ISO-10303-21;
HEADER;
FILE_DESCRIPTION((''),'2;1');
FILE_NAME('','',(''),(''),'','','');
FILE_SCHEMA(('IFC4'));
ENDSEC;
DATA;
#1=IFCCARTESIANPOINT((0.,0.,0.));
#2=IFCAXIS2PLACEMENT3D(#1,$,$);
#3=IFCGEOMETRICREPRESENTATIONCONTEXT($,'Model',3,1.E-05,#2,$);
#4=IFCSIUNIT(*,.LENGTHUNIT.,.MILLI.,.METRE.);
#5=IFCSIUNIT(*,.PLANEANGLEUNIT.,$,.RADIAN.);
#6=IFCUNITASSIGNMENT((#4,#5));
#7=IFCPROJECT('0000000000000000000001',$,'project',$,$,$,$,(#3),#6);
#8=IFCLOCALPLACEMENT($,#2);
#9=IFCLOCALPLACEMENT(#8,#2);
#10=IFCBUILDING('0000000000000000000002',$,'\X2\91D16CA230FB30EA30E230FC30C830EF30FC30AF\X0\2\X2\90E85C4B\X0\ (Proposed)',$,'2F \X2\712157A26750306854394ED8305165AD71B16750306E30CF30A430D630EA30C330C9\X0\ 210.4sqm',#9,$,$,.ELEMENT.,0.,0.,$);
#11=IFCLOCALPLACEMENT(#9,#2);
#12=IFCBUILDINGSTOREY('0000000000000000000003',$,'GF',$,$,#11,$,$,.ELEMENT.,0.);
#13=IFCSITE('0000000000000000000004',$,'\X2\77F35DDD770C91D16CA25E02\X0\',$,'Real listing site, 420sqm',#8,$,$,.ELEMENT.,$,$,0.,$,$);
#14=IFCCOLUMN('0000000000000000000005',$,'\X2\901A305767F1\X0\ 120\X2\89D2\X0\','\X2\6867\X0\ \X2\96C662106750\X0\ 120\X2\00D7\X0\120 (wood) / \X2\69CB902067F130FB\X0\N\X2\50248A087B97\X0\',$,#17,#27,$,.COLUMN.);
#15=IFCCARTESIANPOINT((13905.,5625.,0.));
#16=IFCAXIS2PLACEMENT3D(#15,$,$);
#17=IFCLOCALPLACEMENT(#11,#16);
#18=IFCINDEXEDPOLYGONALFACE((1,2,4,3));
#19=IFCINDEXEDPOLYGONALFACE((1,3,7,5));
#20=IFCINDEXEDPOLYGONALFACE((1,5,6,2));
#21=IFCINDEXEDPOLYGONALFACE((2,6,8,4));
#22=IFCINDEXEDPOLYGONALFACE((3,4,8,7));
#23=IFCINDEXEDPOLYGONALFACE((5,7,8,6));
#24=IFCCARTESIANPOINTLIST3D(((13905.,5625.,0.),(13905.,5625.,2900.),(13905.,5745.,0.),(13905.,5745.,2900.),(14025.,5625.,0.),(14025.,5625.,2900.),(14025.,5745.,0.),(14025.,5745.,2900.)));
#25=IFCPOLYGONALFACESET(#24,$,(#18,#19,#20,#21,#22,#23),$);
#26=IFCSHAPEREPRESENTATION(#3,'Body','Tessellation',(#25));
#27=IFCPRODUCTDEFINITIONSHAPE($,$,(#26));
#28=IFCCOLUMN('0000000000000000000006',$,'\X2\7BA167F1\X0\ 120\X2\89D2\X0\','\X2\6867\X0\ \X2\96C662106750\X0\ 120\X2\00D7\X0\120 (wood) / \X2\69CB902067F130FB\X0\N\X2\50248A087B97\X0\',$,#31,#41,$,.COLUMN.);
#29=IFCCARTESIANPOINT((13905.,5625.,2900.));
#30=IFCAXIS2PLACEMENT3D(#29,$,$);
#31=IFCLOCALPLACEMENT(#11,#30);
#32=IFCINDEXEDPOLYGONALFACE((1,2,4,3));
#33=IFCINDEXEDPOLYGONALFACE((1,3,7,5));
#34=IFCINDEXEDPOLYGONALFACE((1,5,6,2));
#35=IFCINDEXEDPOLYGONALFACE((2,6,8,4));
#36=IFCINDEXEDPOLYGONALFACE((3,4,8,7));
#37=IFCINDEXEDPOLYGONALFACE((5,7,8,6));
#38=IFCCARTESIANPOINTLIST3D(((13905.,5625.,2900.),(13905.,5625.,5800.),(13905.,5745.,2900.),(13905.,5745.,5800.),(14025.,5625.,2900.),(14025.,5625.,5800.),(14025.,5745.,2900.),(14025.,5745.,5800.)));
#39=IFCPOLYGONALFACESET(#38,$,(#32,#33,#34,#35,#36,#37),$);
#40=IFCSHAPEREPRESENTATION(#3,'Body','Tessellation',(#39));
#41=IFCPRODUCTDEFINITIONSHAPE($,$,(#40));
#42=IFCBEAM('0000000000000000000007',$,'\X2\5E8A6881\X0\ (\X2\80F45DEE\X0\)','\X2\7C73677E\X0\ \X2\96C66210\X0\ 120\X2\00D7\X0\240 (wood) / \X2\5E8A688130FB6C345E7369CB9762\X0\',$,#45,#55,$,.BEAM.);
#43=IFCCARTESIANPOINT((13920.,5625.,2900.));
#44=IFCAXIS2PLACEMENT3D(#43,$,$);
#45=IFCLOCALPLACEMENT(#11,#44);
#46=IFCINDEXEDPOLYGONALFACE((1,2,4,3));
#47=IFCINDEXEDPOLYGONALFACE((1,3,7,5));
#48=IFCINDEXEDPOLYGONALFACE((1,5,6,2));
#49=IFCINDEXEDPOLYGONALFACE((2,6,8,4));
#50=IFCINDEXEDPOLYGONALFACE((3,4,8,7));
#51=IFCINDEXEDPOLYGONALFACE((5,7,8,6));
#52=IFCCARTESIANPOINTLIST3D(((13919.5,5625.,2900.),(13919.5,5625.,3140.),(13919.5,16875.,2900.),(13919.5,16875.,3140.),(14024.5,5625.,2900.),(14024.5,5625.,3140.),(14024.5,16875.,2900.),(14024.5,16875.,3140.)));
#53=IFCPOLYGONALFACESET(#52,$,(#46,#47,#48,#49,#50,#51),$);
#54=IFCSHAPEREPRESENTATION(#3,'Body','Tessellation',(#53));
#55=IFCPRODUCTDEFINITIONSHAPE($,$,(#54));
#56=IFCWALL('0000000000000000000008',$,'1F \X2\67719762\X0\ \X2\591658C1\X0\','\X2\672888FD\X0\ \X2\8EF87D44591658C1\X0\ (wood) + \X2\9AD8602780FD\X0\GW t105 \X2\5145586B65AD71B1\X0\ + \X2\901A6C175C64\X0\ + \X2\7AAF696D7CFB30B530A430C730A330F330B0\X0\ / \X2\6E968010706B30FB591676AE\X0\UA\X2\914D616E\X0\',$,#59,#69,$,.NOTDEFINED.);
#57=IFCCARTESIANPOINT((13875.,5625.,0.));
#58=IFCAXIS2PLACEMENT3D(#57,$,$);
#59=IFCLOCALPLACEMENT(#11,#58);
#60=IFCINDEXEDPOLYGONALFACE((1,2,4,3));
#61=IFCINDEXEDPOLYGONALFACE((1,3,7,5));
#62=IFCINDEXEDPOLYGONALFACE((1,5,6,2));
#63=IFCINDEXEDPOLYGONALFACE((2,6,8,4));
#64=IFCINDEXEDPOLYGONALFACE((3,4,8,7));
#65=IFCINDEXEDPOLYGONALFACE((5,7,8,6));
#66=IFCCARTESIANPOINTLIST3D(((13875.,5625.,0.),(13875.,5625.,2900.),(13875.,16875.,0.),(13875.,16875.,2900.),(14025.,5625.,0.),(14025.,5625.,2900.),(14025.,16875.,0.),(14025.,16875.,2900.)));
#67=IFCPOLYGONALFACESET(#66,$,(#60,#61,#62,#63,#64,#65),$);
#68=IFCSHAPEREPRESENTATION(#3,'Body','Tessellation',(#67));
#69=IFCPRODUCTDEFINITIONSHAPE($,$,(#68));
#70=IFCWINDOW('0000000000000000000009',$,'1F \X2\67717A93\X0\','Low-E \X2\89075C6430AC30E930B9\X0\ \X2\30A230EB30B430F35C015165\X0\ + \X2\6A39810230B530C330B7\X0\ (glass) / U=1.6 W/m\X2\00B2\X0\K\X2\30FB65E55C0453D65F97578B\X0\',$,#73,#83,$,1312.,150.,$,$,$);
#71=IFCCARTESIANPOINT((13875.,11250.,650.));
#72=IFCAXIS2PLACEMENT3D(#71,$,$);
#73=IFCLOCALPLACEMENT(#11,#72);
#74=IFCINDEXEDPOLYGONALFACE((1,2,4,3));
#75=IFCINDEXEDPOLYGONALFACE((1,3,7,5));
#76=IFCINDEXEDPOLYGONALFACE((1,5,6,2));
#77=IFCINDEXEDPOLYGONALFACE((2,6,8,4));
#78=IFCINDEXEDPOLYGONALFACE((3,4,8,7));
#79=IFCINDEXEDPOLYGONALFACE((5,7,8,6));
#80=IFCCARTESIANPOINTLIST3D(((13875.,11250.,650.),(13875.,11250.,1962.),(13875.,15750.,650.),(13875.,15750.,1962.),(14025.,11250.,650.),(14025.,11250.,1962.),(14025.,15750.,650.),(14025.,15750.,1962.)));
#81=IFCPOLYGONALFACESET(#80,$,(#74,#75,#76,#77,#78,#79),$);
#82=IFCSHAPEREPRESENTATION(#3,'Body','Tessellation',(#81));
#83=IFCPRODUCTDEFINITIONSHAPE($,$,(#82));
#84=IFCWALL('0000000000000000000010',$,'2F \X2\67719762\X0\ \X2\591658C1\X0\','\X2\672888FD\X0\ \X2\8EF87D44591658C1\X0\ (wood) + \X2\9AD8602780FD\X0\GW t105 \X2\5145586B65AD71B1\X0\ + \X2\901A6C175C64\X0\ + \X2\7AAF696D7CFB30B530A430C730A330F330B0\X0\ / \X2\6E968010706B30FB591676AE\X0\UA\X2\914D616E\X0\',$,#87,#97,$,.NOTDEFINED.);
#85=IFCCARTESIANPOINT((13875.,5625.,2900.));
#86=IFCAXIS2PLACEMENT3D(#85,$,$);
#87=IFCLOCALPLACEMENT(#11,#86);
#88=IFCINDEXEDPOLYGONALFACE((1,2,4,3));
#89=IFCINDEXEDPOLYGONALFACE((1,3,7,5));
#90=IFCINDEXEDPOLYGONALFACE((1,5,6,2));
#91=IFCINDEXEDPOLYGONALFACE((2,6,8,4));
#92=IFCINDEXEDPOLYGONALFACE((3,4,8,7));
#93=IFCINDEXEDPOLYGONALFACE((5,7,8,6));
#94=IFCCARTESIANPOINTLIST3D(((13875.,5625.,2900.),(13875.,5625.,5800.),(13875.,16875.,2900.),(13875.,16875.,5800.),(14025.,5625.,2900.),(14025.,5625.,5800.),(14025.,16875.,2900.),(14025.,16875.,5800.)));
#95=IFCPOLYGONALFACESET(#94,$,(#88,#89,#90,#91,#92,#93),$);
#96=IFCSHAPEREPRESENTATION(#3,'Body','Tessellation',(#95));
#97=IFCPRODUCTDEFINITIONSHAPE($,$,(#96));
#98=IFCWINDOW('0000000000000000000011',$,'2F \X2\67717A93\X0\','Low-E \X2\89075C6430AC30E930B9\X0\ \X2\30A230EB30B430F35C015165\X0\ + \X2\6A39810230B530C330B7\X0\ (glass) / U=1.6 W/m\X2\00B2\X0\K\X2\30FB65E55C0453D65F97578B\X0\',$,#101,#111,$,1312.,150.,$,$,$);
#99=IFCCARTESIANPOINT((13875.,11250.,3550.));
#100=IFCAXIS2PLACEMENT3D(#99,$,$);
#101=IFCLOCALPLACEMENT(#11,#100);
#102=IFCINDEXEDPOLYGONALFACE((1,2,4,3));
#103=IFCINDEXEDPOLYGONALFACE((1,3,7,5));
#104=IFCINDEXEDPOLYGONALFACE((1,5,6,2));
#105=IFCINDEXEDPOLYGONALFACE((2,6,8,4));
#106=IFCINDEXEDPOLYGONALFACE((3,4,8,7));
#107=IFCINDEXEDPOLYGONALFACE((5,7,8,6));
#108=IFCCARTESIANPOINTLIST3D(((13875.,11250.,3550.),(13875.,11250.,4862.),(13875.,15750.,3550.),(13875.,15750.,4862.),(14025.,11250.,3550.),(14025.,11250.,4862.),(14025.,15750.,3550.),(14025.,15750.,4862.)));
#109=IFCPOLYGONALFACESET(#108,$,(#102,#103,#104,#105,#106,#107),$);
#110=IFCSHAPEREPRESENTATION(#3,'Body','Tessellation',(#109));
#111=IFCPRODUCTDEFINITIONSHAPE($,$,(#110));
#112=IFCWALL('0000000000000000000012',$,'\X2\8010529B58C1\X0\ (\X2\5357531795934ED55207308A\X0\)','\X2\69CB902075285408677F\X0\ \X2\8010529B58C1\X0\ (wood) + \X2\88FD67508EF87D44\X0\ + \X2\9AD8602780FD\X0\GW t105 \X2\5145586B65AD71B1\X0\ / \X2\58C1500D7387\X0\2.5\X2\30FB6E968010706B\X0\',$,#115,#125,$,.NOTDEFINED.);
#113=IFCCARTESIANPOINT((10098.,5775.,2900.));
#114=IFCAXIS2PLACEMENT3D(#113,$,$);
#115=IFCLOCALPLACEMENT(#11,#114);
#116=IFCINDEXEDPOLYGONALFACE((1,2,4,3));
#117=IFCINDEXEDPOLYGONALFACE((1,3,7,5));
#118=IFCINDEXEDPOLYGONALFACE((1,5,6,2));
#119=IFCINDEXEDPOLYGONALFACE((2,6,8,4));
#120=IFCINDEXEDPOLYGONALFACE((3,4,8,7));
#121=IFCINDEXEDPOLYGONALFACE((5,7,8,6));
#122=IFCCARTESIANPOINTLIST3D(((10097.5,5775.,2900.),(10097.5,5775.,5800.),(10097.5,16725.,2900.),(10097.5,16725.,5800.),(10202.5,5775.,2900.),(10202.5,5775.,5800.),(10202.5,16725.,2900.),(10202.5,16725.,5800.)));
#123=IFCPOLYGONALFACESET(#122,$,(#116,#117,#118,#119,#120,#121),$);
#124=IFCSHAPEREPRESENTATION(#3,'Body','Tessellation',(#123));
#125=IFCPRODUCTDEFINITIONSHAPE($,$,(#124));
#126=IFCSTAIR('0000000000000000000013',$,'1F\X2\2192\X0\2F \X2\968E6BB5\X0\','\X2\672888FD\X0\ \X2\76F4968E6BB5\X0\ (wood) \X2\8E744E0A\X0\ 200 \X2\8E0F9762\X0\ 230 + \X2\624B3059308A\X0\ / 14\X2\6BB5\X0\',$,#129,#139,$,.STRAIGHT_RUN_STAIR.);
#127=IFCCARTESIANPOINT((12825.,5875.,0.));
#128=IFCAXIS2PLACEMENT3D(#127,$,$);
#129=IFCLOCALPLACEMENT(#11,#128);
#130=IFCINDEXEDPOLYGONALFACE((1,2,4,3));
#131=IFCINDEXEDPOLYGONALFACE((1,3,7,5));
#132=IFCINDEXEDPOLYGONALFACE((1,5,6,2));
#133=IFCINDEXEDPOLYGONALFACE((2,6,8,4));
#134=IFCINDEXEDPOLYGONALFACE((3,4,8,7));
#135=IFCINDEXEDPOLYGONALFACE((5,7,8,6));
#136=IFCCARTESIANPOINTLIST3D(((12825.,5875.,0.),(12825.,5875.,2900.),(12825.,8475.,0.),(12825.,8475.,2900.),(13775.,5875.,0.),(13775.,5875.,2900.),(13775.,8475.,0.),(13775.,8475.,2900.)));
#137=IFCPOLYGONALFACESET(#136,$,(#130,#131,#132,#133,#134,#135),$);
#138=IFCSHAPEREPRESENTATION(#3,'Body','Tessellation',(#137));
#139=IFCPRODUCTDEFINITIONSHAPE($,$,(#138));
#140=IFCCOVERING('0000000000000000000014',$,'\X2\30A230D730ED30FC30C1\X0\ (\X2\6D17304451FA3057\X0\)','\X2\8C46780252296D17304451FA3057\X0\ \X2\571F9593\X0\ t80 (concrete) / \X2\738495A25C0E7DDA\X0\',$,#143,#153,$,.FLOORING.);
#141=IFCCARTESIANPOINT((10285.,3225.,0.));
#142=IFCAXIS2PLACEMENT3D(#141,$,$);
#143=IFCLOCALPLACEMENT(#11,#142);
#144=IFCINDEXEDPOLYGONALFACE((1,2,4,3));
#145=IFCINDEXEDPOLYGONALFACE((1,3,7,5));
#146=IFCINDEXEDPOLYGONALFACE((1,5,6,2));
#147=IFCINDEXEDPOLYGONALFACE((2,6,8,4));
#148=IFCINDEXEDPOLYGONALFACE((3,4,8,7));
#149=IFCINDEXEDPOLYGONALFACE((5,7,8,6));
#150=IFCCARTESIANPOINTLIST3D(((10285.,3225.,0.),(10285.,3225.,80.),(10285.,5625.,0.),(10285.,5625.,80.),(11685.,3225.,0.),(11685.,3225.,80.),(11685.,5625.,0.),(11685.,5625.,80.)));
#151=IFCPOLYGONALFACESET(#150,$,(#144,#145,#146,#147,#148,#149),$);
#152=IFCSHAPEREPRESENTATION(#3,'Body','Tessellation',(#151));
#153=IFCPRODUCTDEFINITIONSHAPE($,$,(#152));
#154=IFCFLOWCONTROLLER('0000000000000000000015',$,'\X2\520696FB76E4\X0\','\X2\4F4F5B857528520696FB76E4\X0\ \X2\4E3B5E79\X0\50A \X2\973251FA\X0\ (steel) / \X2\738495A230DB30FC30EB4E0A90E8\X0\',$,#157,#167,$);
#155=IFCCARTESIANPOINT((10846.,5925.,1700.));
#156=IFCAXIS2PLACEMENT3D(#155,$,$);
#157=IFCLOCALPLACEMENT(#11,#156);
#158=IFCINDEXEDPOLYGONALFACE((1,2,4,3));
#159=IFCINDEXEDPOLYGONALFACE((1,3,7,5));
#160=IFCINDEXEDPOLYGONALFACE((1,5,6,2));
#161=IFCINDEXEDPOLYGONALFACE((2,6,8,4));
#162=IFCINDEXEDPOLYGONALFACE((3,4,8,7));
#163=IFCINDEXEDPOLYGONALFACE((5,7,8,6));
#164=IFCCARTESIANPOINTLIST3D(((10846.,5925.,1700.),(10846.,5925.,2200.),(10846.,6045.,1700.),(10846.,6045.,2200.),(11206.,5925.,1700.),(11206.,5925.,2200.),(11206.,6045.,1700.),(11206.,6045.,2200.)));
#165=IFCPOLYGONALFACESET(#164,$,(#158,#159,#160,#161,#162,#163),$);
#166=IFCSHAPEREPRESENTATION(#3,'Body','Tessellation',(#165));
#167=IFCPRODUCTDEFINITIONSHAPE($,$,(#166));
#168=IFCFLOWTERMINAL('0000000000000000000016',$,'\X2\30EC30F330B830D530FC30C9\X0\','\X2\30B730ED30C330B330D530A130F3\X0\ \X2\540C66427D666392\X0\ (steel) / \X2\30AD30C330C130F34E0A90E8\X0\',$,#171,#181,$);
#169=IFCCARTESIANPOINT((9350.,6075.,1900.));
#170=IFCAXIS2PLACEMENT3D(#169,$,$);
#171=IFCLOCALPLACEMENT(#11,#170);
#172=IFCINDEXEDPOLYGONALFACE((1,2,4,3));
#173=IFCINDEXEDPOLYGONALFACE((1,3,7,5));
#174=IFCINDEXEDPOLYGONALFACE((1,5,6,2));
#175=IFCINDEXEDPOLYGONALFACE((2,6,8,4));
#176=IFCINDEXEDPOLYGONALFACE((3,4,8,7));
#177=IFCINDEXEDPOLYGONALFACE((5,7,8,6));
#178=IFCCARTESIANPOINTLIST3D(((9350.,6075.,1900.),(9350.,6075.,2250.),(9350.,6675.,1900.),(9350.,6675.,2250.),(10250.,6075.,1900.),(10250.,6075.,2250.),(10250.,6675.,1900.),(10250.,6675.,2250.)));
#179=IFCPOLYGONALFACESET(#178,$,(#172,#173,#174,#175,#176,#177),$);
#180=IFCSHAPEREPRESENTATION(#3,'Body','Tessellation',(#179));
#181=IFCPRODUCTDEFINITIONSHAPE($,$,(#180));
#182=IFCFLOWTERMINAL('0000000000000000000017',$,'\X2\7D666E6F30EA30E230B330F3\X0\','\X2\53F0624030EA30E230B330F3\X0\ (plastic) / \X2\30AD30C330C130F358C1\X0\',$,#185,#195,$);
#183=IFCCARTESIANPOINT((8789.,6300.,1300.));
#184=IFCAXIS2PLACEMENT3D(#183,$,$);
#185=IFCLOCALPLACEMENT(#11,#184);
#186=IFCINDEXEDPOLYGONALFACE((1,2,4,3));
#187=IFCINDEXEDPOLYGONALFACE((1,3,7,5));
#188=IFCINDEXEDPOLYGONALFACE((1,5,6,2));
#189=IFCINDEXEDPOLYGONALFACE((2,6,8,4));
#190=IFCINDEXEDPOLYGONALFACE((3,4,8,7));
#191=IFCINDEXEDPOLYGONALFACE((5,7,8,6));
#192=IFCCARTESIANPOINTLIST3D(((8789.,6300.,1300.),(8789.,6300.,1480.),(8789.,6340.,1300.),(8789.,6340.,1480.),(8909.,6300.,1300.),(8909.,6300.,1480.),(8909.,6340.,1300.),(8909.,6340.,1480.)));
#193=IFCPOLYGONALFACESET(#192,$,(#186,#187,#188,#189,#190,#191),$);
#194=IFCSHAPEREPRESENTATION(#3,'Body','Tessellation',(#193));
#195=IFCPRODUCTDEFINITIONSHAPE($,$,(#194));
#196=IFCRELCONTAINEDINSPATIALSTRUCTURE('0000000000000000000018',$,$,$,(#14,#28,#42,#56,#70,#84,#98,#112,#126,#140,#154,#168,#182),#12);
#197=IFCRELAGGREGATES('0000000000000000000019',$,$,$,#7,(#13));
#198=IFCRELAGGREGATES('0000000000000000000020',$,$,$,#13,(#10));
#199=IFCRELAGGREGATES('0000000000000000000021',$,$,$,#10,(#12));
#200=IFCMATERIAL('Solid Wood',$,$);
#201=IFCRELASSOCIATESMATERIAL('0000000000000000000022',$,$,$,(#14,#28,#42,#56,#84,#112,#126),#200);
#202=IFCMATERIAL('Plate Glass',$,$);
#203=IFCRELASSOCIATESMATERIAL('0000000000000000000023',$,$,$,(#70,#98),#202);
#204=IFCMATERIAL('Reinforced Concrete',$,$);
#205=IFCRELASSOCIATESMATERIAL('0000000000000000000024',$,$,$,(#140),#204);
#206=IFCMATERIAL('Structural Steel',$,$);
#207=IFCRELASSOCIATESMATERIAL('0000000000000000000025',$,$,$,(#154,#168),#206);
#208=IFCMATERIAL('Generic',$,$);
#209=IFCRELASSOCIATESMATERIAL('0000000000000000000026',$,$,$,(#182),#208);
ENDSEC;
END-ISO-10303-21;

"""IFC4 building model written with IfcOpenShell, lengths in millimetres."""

from ifc_helpers import new_model, si_unit, frame, frame_2d, origin, place, context, project, spatial, rectangle, extrude, material, element, fill, save


model = new_model("IFC4")

# Units and contexts
model_context = context("Model", 3, precision=1e-05, world=origin())
ifc_project = project(units=[si_unit("LENGTHUNIT", "METRE", prefix="MILLI"), si_unit("PLANEANGLEUNIT", "RADIAN")], contexts=[model_context])

# Site, building, storey
site_placement = place(None, origin())
site = spatial("IfcSite", under=ifc_project, at=site_placement, Name="石川県金沢市", ObjectType="Real listing site, 420sqm", CompositionType="ELEMENT", RefElevation=0.0)
building_placement = place(site_placement, origin())
building = spatial("IfcBuilding", under=site, at=building_placement, Name="金沢・リモートワーク2部屋 (Proposed)", ObjectType="2F 無垢材と吹付け断熱材のハイブリッド 210.4sqm", CompositionType="ELEMENT", ElevationOfRefHeight=0.0, ElevationOfTerrain=0.0)
storey_placement = place(building_placement, origin())
storey = spatial("IfcBuildingStorey", under=building, at=storey_placement, Name="GF", CompositionType="ELEMENT", Elevation=0.0)

# Columns
ifc_material_1 = material(Name="Solid Wood")
column_1_placement = place(storey_placement, frame((13905.0, 5625.0, 0.0)))
element("IfcColumn", 1, at=column_1_placement, inside=storey, material=ifc_material_1, Name="通し柱 120角", Description="桧 集成材 120×120 (wood) / 構造柱・N値計算", PredefinedType="COLUMN", context=model_context, shape_type="SweptSolid", body=[
    extrude(rectangle(XDim=120.0, YDim=120.0, at=frame_2d((60.0, 60.0))), frame((13905.0, 5625.0, 0.0)), (0.0, 0.0, 1.0), 2900.0),
])
column_2_placement = place(storey_placement, frame((13905.0, 5625.0, 2900.0)))
element("IfcColumn", 2, at=column_2_placement, inside=storey, material=ifc_material_1, Name="管柱 120角", Description="桧 集成材 120×120 (wood) / 構造柱・N値計算", PredefinedType="COLUMN", context=model_context, shape_type="SweptSolid", body=[
    extrude(rectangle(XDim=120.0, YDim=120.0, at=frame_2d((60.0, 60.0))), frame((13905.0, 5625.0, 2900.0)), (0.0, 0.0, 1.0), 2900.0),
])

# Beam
beam_1_placement = place(storey_placement, frame((13920.0, 5625.0, 2900.0)))
element("IfcBeam", 3, at=beam_1_placement, inside=storey, material=ifc_material_1, Name="床梁 (胴差)", Description="米松 集成 120×240 (wood) / 床梁・水平構面", PredefinedType="BEAM", context=model_context, shape_type="SweptSolid", body=[
    extrude(rectangle(XDim=105.0, YDim=11250.0, at=frame_2d((52.0, 5625.0))), frame((13920.0, 5625.0, 2900.0)), (0.0, 0.0, 1.0), 240.0),
])

# Wall, opening, window
wall_1_placement = place(storey_placement, frame((13875.0, 5625.0, 0.0)))
wall_1 = element("IfcWall", 4, at=wall_1_placement, inside=storey, material=ifc_material_1, Name="1F 東面 外壁", Description="木製 軸組外壁 (wood) + 高性能GW t105 充填断熱 + 通気層 + 窯業系サイディング / 準耐火・外皮UA配慮", PredefinedType="NOTDEFINED", context=model_context, shape_type="SweptSolid", body=[
    extrude(rectangle(XDim=150.0, YDim=11250.0, at=frame_2d((75.0, 5625.0))), frame((13875.0, 5625.0, 0.0)), (0.0, 0.0, 1.0), 2900.0),
])
opening_1_placement = place(storey_placement, frame((13875.0, 11250.0, 650.0)))
opening_1 = element("IfcOpeningElement", 5, at=opening_1_placement, cuts=wall_1, PredefinedType="NOTDEFINED", context=model_context, shape_type="SweptSolid", body=[
    extrude(rectangle(XDim=150.0, YDim=4500.0, at=frame_2d((75.0, 2250.0))), frame((13875.0, 11250.0, 650.0)), (0.0, 0.0, 1.0), 1312.0),
])
ifc_material_2 = material(Name="Plate Glass")
window_1_placement = place(storey_placement, frame((13875.0, 11250.0, 650.0)))
window_1 = element("IfcWindow", 6, at=window_1_placement, inside=storey, material=ifc_material_2, Name="1F 東窓", Description="Low-E 複層ガラス アルゴン封入 + 樹脂サッシ (glass) / U=1.6 W/m²K・日射取得型", OverallHeight=1312.0, OverallWidth=150.0, context=model_context, shape_type="SweptSolid", body=[
    extrude(rectangle(XDim=150.0, YDim=4500.0, at=frame_2d((75.0, 2250.0))), frame((13875.0, 11250.0, 650.0)), (0.0, 0.0, 1.0), 1312.0),
])
fill(opening_1, window_1)

# Wall, opening, window
wall_2_placement = place(storey_placement, frame((13875.0, 5625.0, 2900.0)))
wall_2 = element("IfcWall", 7, at=wall_2_placement, inside=storey, material=ifc_material_1, Name="2F 東面 外壁", Description="木製 軸組外壁 (wood) + 高性能GW t105 充填断熱 + 通気層 + 窯業系サイディング / 準耐火・外皮UA配慮", PredefinedType="NOTDEFINED", context=model_context, shape_type="SweptSolid", body=[
    extrude(rectangle(XDim=150.0, YDim=11250.0, at=frame_2d((75.0, 5625.0))), frame((13875.0, 5625.0, 2900.0)), (0.0, 0.0, 1.0), 2900.0),
])
opening_2_placement = place(storey_placement, frame((13875.0, 11250.0, 3550.0)))
opening_2 = element("IfcOpeningElement", 8, at=opening_2_placement, cuts=wall_2, PredefinedType="NOTDEFINED", context=model_context, shape_type="SweptSolid", body=[
    extrude(rectangle(XDim=150.0, YDim=4500.0, at=frame_2d((75.0, 2250.0))), frame((13875.0, 11250.0, 3550.0)), (0.0, 0.0, 1.0), 1312.0),
])
window_2_placement = place(storey_placement, frame((13875.0, 11250.0, 3550.0)))
window_2 = element("IfcWindow", 9, at=window_2_placement, inside=storey, material=ifc_material_2, Name="2F 東窓", Description="Low-E 複層ガラス アルゴン封入 + 樹脂サッシ (glass) / U=1.6 W/m²K・日射取得型", OverallHeight=1312.0, OverallWidth=150.0, context=model_context, shape_type="SweptSolid", body=[
    extrude(rectangle(XDim=150.0, YDim=4500.0, at=frame_2d((75.0, 2250.0))), frame((13875.0, 11250.0, 3550.0)), (0.0, 0.0, 1.0), 1312.0),
])
fill(opening_2, window_2)

# Wall
wall_3_placement = place(storey_placement, frame((10098.0, 5775.0, 2900.0)))
element("IfcWall", 10, at=wall_3_placement, inside=storey, material=ifc_material_1, Name="耐力壁 (南北間仕切り)", Description="構造用合板 耐力壁 (wood) + 製材軸組 + 高性能GW t105 充填断熱 / 壁倍率2.5・準耐火", PredefinedType="NOTDEFINED", context=model_context, shape_type="SweptSolid", body=[
    extrude(rectangle(XDim=105.0, YDim=10950.0, at=frame_2d((52.0, 5475.0))), frame((10098.0, 5775.0, 2900.0)), (0.0, 0.0, 1.0), 2900.0),
])

# Stair
stair_placement = place(storey_placement, frame((12825.0, 5875.0, 0.0)))
element("IfcStair", 11, at=stair_placement, inside=storey, material=ifc_material_1, Name="1F→2F 階段", Description="木製 直階段 (wood) 蹴上 200 踏面 230 + 手すり / 14段", PredefinedType="STRAIGHT_RUN_STAIR", context=model_context, shape_type="SweptSolid", body=[
    extrude(rectangle(XDim=950.0, YDim=2600.0, at=frame_2d((475.0, 1300.0))), frame((12825.0, 5875.0, 0.0)), (0.0, 0.0, 1.0), 2900.0),
])

# Covering
ifc_material_3 = material(Name="Reinforced Concrete")
covering_placement = place(storey_placement, frame((10285.0, 3225.0, 0.0)))
element("IfcCovering", 12, at=covering_placement, inside=storey, material=ifc_material_3, Name="アプローチ (洗い出し)", Description="豆砂利洗い出し 土間 t80 (concrete) / 玄関導線", PredefinedType="FLOORING", context=model_context, shape_type="SweptSolid", body=[
    extrude(rectangle(XDim=1400.0, YDim=2400.0, at=frame_2d((700.0, 1200.0))), frame((10285.0, 3225.0, 0.0)), (0.0, 0.0, 1.0), 80.0),
])

# Flow controller
ifc_material_4 = material(Name="Structural Steel")
flow_controller_placement = place(storey_placement, frame((10846.0, 5925.0, 1700.0)))
element("IfcFlowController", 13, at=flow_controller_placement, inside=storey, material=ifc_material_4, Name="分電盤", Description="住宅用分電盤 主幹50A 露出 (steel) / 玄関ホール上部", context=model_context, shape_type="SweptSolid", body=[
    extrude(rectangle(XDim=360.0, YDim=120.0, at=frame_2d((180.0, 60.0))), frame((10846.0, 5925.0, 1700.0)), (0.0, 0.0, 1.0), 500.0),
])

# Flow terminals
flow_terminal_1_placement = place(storey_placement, frame((9350.0, 6075.0, 1900.0)))
element("IfcFlowTerminal", 14, at=flow_terminal_1_placement, inside=storey, material=ifc_material_4, Name="レンジフード", Description="シロッコファン 同時給排 (steel) / キッチン上部", context=model_context, shape_type="SweptSolid", body=[
    extrude(rectangle(XDim=900.0, YDim=600.0, at=frame_2d((450.0, 300.0))), frame((9350.0, 6075.0, 1900.0)), (0.0, 0.0, 1.0), 350.0),
])
ifc_material_5 = material(Name="Generic")
flow_terminal_2_placement = place(storey_placement, frame((8789.0, 6300.0, 1300.0)))
element("IfcFlowTerminal", 15, at=flow_terminal_2_placement, inside=storey, material=ifc_material_5, Name="給湯リモコン", Description="台所リモコン (plastic) / キッチン壁", context=model_context, shape_type="SweptSolid", body=[
    extrude(rectangle(XDim=120.0, YDim=40.0, at=frame_2d((60.0, 20.0))), frame((8789.0, 6300.0, 1300.0)), (0.0, 0.0, 1.0), 180.0),
])

save(model, "model.ifc")
